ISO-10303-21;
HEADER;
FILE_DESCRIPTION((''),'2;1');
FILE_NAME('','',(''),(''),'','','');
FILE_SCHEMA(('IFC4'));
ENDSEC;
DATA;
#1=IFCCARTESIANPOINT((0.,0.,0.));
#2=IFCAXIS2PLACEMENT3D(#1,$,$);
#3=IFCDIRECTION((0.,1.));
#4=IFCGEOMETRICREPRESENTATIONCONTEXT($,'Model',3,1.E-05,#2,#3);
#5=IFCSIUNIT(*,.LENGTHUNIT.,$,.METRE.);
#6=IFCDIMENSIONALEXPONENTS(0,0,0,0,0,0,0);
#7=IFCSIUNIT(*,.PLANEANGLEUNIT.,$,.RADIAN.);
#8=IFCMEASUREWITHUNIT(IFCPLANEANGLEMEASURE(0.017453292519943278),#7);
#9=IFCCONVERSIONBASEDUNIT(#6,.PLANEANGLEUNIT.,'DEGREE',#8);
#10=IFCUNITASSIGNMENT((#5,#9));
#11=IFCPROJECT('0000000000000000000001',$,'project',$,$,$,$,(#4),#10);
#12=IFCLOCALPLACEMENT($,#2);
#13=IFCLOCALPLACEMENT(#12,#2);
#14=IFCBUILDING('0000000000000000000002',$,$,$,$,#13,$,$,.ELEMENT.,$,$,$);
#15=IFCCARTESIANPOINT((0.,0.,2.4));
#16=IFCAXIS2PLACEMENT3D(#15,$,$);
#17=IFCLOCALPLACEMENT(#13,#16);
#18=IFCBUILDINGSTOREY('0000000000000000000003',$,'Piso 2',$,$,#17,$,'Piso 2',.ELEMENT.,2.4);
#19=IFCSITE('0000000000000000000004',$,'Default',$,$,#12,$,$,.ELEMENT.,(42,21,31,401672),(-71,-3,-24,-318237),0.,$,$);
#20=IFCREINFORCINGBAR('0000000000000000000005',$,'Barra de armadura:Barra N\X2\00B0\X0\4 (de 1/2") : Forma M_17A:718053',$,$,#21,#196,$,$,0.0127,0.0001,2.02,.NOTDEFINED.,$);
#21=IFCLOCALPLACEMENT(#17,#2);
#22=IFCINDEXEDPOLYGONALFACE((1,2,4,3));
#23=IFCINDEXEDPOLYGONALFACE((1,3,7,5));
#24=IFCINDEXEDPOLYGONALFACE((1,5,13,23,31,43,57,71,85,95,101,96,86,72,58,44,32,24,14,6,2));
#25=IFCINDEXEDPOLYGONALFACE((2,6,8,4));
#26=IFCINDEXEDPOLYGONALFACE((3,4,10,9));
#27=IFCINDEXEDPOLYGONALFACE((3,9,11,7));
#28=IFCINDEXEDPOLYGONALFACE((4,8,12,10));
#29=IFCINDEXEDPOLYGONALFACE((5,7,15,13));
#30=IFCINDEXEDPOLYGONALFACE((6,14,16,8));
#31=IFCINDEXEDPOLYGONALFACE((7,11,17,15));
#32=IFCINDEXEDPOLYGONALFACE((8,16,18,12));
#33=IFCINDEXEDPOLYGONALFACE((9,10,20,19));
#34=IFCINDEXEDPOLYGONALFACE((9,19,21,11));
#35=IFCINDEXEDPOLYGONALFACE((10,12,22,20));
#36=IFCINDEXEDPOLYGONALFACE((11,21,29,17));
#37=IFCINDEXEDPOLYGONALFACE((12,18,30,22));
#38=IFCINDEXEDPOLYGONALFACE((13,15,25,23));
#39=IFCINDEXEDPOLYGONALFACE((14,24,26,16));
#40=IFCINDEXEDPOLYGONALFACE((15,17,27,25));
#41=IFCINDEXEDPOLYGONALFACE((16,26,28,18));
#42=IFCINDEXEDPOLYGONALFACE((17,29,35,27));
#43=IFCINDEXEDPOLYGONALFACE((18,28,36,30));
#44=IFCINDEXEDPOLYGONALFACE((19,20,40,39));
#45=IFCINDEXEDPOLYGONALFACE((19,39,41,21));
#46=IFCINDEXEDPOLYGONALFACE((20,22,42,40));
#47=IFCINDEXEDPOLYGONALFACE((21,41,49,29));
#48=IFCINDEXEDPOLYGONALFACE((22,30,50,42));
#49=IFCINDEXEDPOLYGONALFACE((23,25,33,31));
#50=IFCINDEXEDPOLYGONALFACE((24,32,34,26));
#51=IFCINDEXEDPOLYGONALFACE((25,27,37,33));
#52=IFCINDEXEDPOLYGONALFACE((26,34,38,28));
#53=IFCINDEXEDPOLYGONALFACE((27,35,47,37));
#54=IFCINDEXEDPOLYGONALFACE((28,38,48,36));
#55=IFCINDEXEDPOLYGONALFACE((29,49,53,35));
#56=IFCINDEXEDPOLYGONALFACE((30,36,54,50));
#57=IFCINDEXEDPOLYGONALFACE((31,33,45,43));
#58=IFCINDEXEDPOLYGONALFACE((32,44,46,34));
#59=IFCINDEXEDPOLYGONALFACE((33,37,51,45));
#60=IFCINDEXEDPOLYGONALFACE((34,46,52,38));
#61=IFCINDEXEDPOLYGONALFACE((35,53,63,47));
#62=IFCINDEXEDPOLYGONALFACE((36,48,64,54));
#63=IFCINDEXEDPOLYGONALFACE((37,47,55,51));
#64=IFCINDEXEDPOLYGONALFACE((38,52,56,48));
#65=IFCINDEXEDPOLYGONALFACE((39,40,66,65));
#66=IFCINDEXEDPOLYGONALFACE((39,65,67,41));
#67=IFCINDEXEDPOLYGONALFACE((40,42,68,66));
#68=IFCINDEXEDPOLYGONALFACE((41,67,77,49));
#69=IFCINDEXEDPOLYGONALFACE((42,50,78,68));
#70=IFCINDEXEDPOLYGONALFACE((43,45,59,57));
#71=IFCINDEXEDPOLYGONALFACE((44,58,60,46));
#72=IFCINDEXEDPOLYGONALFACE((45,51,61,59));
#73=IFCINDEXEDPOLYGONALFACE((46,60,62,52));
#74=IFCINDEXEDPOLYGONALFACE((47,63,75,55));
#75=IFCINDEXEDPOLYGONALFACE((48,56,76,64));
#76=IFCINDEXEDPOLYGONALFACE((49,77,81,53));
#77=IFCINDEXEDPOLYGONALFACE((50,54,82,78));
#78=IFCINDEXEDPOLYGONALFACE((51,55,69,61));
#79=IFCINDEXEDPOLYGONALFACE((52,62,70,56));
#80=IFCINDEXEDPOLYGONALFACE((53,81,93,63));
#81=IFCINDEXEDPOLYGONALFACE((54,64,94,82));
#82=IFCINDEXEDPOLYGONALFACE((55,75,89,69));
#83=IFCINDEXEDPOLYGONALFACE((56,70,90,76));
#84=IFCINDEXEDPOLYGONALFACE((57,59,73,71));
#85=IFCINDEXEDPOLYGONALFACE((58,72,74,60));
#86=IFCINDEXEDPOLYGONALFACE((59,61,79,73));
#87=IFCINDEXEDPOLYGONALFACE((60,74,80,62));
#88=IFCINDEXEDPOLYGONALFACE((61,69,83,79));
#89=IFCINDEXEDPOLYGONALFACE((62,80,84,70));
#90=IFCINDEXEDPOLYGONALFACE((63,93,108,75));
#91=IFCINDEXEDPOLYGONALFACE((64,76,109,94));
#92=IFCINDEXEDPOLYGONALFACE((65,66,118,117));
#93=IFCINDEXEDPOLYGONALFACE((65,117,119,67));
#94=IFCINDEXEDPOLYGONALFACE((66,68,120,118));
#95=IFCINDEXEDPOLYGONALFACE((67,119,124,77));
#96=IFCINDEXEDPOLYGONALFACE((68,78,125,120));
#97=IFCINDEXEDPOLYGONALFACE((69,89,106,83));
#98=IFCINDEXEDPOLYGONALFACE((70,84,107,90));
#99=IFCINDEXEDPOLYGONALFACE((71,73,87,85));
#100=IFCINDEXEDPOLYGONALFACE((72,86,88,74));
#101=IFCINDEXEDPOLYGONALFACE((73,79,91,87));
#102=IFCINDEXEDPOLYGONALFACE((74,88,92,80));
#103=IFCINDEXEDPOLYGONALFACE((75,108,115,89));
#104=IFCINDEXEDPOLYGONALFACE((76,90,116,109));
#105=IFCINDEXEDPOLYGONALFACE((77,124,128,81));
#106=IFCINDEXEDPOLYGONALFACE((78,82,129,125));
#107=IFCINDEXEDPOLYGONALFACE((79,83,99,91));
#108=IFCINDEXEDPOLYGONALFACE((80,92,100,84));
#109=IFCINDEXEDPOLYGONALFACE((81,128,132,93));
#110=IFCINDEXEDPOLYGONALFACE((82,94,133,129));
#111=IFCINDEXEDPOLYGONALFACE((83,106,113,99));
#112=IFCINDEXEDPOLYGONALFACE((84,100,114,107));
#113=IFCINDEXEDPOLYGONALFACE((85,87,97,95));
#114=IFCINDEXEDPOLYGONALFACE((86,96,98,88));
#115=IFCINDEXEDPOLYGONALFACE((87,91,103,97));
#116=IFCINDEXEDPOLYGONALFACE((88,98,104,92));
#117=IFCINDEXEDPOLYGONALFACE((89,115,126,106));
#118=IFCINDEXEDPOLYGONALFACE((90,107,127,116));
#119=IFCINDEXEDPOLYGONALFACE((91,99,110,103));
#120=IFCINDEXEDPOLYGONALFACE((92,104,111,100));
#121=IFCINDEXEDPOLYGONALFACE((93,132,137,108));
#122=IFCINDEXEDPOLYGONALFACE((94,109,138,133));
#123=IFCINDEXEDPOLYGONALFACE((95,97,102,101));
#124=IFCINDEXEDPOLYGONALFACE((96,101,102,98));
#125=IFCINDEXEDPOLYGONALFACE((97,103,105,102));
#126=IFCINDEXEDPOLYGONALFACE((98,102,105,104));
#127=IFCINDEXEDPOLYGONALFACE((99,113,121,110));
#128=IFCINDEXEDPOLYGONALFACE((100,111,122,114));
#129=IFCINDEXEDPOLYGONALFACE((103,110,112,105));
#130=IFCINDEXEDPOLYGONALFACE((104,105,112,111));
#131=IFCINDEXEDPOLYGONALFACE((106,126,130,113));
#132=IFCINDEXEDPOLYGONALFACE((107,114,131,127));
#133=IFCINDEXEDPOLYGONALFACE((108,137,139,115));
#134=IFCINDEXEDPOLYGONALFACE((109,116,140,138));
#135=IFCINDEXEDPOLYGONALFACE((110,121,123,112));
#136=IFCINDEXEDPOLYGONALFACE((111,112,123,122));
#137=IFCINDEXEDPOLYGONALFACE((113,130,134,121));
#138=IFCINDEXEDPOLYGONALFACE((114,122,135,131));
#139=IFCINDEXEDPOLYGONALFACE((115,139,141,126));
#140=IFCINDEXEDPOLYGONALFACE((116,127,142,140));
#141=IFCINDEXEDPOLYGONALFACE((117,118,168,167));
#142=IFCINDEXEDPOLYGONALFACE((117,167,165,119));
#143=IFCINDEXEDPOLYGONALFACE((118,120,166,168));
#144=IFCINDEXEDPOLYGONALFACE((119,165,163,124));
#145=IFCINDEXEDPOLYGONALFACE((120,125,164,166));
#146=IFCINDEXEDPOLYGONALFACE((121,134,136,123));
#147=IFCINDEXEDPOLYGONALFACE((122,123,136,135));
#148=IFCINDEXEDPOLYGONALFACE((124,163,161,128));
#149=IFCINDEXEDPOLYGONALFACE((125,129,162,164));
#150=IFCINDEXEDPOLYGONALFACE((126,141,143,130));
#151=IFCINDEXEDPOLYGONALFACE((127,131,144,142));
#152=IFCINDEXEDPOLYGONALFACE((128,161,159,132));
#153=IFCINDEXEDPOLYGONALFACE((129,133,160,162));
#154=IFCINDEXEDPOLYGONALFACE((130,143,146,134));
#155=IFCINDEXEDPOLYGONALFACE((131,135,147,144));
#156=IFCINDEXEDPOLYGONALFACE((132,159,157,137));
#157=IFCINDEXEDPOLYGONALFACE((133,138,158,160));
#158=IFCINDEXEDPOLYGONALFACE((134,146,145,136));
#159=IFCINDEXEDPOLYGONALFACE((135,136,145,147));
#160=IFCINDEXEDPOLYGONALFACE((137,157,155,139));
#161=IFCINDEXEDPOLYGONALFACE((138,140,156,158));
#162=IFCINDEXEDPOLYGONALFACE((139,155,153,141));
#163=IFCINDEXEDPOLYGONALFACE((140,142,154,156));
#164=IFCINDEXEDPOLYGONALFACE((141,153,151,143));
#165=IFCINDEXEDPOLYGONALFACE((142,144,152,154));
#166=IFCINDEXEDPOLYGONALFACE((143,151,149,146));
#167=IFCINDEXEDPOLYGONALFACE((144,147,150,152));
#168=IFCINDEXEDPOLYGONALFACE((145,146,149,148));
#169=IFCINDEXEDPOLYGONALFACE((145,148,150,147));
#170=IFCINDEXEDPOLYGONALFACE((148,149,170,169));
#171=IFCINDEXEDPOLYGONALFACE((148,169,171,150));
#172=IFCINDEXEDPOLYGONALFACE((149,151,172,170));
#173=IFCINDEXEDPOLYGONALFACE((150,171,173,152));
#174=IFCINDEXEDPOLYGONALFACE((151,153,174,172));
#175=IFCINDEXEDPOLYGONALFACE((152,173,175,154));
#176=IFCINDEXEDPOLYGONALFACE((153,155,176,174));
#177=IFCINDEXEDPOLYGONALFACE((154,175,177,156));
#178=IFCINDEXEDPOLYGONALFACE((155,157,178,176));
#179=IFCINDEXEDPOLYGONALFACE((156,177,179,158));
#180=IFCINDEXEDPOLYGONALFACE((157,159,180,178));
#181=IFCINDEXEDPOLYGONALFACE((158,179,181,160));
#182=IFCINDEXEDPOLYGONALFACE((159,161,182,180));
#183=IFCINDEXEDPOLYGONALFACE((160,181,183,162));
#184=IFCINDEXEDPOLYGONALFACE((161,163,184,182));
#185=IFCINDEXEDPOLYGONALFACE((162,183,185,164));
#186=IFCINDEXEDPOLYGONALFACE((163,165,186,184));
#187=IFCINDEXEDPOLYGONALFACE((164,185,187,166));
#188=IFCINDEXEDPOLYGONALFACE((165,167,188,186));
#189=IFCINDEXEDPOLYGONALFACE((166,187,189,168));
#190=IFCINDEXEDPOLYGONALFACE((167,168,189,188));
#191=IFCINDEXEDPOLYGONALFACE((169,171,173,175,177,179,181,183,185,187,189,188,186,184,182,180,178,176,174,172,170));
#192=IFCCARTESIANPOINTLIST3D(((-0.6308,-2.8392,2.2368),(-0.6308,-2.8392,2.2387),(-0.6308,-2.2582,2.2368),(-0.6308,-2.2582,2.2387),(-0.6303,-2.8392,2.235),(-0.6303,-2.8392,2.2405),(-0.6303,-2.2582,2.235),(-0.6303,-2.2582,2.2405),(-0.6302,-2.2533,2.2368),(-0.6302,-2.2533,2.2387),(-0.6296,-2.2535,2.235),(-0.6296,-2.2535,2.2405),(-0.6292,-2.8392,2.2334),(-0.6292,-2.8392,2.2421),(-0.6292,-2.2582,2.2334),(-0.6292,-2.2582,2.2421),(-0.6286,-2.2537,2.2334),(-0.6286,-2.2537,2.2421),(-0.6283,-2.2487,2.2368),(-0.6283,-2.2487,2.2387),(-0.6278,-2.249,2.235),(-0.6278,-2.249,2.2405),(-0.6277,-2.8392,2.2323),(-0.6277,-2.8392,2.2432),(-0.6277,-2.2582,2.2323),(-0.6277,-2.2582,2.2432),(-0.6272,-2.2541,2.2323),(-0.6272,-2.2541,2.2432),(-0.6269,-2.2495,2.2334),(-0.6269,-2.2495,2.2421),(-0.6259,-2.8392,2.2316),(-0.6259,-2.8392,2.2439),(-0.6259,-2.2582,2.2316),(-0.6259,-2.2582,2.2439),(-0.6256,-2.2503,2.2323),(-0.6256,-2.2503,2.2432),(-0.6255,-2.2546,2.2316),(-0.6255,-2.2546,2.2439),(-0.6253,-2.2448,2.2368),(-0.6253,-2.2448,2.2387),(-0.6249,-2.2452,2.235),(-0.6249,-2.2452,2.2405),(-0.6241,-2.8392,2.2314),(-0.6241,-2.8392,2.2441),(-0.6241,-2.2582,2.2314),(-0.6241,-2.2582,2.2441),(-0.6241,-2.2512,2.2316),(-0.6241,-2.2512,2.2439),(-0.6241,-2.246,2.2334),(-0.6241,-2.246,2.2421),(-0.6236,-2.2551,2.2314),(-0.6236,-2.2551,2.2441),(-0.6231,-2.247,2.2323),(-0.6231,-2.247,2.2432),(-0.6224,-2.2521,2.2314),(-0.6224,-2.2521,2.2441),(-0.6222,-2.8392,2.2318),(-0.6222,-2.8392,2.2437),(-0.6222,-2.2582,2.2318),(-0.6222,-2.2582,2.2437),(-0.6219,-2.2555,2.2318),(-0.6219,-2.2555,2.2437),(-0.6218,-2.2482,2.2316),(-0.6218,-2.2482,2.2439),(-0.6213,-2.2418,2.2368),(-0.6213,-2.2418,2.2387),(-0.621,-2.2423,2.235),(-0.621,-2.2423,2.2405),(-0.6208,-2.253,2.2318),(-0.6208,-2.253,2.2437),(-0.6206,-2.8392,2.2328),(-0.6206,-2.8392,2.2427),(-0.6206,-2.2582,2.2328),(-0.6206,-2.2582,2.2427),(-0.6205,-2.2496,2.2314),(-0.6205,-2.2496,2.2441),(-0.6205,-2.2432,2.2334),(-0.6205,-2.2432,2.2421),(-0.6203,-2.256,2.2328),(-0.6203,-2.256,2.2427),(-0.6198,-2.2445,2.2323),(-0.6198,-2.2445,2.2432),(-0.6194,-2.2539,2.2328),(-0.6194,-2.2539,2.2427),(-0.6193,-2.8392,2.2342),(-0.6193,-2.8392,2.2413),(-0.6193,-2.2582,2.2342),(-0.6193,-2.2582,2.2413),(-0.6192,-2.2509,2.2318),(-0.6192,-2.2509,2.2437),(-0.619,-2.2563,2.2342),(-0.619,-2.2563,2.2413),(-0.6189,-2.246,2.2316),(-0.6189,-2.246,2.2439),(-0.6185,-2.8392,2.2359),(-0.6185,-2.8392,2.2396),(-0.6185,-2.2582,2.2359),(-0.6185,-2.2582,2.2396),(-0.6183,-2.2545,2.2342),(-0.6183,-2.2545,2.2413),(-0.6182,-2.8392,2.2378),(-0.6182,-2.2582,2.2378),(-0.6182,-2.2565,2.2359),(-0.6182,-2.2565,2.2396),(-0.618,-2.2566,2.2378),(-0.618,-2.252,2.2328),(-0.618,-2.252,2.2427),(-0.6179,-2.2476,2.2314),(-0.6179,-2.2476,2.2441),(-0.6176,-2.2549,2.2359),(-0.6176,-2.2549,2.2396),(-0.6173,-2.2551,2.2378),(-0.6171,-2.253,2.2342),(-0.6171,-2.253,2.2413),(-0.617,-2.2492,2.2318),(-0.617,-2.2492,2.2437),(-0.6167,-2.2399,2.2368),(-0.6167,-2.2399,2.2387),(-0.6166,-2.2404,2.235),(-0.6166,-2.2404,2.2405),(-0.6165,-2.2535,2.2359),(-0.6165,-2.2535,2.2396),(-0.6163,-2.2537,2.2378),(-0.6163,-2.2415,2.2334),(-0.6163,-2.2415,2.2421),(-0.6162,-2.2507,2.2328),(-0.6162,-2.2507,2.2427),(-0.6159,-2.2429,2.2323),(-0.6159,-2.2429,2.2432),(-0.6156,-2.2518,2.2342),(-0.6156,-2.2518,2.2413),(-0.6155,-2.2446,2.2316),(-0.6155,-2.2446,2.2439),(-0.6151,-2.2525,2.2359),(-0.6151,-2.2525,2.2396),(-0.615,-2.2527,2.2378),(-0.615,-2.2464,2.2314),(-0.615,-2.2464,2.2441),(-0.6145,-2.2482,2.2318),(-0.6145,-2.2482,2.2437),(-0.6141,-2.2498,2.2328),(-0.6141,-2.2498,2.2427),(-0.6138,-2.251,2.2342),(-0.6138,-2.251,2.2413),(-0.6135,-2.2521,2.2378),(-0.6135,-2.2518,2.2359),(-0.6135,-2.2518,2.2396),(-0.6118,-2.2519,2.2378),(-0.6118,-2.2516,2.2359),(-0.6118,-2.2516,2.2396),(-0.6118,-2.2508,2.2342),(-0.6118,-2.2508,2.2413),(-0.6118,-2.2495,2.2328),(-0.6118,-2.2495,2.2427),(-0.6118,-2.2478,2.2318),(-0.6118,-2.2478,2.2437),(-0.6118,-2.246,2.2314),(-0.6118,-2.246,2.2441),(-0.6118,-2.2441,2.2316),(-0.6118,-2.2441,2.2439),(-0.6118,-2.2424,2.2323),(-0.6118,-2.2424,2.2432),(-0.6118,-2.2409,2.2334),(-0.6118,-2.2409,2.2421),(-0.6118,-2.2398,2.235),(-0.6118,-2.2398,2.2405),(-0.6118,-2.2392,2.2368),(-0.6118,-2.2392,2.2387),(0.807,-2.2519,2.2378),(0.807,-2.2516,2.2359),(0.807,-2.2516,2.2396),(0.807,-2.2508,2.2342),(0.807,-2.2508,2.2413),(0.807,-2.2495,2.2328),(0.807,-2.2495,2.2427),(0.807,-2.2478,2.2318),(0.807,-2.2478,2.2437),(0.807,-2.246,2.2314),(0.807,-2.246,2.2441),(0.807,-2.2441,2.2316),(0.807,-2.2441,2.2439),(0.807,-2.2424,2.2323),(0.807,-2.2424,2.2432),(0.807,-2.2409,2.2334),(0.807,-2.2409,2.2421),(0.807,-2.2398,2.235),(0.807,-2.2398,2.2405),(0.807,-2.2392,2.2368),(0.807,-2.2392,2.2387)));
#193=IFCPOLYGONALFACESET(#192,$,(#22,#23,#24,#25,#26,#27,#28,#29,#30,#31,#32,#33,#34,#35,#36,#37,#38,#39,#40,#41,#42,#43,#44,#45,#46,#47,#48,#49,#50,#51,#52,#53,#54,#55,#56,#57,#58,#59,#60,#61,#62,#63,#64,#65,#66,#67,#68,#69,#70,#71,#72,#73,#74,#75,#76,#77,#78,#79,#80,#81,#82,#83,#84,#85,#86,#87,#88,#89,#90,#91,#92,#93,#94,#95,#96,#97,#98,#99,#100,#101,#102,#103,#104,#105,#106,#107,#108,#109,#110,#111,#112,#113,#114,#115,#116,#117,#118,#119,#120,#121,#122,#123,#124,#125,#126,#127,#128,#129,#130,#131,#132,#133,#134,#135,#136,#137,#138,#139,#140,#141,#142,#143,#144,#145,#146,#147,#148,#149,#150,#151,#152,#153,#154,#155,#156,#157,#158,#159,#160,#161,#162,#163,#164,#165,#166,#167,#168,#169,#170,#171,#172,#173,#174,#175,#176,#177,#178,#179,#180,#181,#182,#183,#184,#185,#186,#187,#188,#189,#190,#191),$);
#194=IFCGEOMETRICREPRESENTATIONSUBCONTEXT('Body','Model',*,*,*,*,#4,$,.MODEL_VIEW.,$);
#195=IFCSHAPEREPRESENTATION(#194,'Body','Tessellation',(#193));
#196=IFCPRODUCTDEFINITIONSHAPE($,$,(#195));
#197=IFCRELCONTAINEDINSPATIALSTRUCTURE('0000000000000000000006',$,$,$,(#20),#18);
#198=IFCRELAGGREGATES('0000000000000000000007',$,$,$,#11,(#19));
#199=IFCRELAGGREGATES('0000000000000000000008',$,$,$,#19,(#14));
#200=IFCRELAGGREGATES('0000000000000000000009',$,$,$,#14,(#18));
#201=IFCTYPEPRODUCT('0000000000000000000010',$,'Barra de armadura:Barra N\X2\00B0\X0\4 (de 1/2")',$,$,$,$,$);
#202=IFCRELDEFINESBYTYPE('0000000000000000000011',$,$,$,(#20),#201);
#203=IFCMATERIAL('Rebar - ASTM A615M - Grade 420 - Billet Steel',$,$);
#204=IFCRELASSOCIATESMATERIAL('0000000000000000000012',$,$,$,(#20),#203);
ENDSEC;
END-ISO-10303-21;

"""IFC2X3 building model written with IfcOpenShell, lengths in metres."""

from ifc_helpers import new_model, entity, si_unit, converted_unit, direction, frame, origin, place, context, subcontext, project, spatial, material, type_object, element, save


model = new_model("IFC2X3")

# Units and contexts
model_context = context("Model", 3, precision=1e-05, world=origin(), true_north=direction((0.0, 1.0)))
body_context = subcontext(model_context, "Body", "Model", "MODEL_VIEW")
ifc_project = project(units=[si_unit("LENGTHUNIT", "METRE"), converted_unit("PLANEANGLEUNIT", "DEGREE", entity("IfcPlaneAngleMeasure", 0.017453292519943278), si_unit("PLANEANGLEUNIT", "RADIAN"), dimensions=[0, 0, 0, 0, 0, 0, 0])], contexts=[model_context])

# Site, building, storey
site_placement = place(None, origin())
site = spatial("IfcSite", under=ifc_project, at=site_placement, Name="Default", CompositionType="ELEMENT", RefLatitude=(42, 21, 31, 401672), RefLongitude=(-71, -3, -24, -318237), RefElevation=0.0)
building_placement = place(site_placement, origin())
building = spatial("IfcBuilding", under=site, at=building_placement, CompositionType="ELEMENT")
storey_placement = place(building_placement, frame((0.0, 0.0, 2.4)))
storey = spatial("IfcBuildingStorey", under=building, at=storey_placement, Name="Piso 2", LongName="Piso 2", CompositionType="ELEMENT", Elevation=2.4)

# Reinforcing bar
ifc_material_1 = material(Name="Rebar - ASTM A615M - Grade 420 - Billet Steel")
type_product_1 = type_object("IfcTypeProduct", Name="Barra de armadura:Barra N°4 (de 1/2\")")
reinforcing_bar_1_placement = place(storey_placement, origin())
element("IfcReinforcingBar", 1, at=reinforcing_bar_1_placement, inside=storey, type_object=type_product_1, material=ifc_material_1, Name="Barra de armadura:Barra N°4 (de 1/2\") : Forma M_17A:718053", BarLength=2.02, BarRole="NOTDEFINED", CrossSectionArea=0.0001, NominalDiameter=0.0127, context=body_context, shape_type="AdvancedSweptSolid", body=[
    entity("IfcSweptDiskSolid", entity("IfcCompositeCurve", [entity("IfcCompositeCurveSegment", "CONTINUOUS", True, entity("IfcPolyline", [entity("IfcCartesianPoint", [0.807, -2.2455, 2.2378]), entity("IfcCartesianPoint", [-0.6118, -2.2455, 2.2378])])), entity("IfcCompositeCurveSegment", "CONTINUOUS", True, entity("IfcTrimmedCurve", entity("IfcCircle", entity("IfcAxis2Placement3D", entity("IfcCartesianPoint", [-0.6118, -2.2582, 2.2378]), entity("IfcDirection", [0.0, 0.0, 1.0]), entity("IfcDirection", [-1.0, 0.0, 0.0])), 0.0127), [entity("IfcParameterValue", 270.0)], [entity("IfcParameterValue", 360.0)], True, "PARAMETER")), entity("IfcCompositeCurveSegment", "CONTINUOUS", True, entity("IfcPolyline", [entity("IfcCartesianPoint", [-0.6245, -2.2582, 2.2378]), entity("IfcCartesianPoint", [-0.6245, -2.8392, 2.2378])]))], False), 0.0063, None, 0.0, 92.0),
])

save(model, "model.ifc")
